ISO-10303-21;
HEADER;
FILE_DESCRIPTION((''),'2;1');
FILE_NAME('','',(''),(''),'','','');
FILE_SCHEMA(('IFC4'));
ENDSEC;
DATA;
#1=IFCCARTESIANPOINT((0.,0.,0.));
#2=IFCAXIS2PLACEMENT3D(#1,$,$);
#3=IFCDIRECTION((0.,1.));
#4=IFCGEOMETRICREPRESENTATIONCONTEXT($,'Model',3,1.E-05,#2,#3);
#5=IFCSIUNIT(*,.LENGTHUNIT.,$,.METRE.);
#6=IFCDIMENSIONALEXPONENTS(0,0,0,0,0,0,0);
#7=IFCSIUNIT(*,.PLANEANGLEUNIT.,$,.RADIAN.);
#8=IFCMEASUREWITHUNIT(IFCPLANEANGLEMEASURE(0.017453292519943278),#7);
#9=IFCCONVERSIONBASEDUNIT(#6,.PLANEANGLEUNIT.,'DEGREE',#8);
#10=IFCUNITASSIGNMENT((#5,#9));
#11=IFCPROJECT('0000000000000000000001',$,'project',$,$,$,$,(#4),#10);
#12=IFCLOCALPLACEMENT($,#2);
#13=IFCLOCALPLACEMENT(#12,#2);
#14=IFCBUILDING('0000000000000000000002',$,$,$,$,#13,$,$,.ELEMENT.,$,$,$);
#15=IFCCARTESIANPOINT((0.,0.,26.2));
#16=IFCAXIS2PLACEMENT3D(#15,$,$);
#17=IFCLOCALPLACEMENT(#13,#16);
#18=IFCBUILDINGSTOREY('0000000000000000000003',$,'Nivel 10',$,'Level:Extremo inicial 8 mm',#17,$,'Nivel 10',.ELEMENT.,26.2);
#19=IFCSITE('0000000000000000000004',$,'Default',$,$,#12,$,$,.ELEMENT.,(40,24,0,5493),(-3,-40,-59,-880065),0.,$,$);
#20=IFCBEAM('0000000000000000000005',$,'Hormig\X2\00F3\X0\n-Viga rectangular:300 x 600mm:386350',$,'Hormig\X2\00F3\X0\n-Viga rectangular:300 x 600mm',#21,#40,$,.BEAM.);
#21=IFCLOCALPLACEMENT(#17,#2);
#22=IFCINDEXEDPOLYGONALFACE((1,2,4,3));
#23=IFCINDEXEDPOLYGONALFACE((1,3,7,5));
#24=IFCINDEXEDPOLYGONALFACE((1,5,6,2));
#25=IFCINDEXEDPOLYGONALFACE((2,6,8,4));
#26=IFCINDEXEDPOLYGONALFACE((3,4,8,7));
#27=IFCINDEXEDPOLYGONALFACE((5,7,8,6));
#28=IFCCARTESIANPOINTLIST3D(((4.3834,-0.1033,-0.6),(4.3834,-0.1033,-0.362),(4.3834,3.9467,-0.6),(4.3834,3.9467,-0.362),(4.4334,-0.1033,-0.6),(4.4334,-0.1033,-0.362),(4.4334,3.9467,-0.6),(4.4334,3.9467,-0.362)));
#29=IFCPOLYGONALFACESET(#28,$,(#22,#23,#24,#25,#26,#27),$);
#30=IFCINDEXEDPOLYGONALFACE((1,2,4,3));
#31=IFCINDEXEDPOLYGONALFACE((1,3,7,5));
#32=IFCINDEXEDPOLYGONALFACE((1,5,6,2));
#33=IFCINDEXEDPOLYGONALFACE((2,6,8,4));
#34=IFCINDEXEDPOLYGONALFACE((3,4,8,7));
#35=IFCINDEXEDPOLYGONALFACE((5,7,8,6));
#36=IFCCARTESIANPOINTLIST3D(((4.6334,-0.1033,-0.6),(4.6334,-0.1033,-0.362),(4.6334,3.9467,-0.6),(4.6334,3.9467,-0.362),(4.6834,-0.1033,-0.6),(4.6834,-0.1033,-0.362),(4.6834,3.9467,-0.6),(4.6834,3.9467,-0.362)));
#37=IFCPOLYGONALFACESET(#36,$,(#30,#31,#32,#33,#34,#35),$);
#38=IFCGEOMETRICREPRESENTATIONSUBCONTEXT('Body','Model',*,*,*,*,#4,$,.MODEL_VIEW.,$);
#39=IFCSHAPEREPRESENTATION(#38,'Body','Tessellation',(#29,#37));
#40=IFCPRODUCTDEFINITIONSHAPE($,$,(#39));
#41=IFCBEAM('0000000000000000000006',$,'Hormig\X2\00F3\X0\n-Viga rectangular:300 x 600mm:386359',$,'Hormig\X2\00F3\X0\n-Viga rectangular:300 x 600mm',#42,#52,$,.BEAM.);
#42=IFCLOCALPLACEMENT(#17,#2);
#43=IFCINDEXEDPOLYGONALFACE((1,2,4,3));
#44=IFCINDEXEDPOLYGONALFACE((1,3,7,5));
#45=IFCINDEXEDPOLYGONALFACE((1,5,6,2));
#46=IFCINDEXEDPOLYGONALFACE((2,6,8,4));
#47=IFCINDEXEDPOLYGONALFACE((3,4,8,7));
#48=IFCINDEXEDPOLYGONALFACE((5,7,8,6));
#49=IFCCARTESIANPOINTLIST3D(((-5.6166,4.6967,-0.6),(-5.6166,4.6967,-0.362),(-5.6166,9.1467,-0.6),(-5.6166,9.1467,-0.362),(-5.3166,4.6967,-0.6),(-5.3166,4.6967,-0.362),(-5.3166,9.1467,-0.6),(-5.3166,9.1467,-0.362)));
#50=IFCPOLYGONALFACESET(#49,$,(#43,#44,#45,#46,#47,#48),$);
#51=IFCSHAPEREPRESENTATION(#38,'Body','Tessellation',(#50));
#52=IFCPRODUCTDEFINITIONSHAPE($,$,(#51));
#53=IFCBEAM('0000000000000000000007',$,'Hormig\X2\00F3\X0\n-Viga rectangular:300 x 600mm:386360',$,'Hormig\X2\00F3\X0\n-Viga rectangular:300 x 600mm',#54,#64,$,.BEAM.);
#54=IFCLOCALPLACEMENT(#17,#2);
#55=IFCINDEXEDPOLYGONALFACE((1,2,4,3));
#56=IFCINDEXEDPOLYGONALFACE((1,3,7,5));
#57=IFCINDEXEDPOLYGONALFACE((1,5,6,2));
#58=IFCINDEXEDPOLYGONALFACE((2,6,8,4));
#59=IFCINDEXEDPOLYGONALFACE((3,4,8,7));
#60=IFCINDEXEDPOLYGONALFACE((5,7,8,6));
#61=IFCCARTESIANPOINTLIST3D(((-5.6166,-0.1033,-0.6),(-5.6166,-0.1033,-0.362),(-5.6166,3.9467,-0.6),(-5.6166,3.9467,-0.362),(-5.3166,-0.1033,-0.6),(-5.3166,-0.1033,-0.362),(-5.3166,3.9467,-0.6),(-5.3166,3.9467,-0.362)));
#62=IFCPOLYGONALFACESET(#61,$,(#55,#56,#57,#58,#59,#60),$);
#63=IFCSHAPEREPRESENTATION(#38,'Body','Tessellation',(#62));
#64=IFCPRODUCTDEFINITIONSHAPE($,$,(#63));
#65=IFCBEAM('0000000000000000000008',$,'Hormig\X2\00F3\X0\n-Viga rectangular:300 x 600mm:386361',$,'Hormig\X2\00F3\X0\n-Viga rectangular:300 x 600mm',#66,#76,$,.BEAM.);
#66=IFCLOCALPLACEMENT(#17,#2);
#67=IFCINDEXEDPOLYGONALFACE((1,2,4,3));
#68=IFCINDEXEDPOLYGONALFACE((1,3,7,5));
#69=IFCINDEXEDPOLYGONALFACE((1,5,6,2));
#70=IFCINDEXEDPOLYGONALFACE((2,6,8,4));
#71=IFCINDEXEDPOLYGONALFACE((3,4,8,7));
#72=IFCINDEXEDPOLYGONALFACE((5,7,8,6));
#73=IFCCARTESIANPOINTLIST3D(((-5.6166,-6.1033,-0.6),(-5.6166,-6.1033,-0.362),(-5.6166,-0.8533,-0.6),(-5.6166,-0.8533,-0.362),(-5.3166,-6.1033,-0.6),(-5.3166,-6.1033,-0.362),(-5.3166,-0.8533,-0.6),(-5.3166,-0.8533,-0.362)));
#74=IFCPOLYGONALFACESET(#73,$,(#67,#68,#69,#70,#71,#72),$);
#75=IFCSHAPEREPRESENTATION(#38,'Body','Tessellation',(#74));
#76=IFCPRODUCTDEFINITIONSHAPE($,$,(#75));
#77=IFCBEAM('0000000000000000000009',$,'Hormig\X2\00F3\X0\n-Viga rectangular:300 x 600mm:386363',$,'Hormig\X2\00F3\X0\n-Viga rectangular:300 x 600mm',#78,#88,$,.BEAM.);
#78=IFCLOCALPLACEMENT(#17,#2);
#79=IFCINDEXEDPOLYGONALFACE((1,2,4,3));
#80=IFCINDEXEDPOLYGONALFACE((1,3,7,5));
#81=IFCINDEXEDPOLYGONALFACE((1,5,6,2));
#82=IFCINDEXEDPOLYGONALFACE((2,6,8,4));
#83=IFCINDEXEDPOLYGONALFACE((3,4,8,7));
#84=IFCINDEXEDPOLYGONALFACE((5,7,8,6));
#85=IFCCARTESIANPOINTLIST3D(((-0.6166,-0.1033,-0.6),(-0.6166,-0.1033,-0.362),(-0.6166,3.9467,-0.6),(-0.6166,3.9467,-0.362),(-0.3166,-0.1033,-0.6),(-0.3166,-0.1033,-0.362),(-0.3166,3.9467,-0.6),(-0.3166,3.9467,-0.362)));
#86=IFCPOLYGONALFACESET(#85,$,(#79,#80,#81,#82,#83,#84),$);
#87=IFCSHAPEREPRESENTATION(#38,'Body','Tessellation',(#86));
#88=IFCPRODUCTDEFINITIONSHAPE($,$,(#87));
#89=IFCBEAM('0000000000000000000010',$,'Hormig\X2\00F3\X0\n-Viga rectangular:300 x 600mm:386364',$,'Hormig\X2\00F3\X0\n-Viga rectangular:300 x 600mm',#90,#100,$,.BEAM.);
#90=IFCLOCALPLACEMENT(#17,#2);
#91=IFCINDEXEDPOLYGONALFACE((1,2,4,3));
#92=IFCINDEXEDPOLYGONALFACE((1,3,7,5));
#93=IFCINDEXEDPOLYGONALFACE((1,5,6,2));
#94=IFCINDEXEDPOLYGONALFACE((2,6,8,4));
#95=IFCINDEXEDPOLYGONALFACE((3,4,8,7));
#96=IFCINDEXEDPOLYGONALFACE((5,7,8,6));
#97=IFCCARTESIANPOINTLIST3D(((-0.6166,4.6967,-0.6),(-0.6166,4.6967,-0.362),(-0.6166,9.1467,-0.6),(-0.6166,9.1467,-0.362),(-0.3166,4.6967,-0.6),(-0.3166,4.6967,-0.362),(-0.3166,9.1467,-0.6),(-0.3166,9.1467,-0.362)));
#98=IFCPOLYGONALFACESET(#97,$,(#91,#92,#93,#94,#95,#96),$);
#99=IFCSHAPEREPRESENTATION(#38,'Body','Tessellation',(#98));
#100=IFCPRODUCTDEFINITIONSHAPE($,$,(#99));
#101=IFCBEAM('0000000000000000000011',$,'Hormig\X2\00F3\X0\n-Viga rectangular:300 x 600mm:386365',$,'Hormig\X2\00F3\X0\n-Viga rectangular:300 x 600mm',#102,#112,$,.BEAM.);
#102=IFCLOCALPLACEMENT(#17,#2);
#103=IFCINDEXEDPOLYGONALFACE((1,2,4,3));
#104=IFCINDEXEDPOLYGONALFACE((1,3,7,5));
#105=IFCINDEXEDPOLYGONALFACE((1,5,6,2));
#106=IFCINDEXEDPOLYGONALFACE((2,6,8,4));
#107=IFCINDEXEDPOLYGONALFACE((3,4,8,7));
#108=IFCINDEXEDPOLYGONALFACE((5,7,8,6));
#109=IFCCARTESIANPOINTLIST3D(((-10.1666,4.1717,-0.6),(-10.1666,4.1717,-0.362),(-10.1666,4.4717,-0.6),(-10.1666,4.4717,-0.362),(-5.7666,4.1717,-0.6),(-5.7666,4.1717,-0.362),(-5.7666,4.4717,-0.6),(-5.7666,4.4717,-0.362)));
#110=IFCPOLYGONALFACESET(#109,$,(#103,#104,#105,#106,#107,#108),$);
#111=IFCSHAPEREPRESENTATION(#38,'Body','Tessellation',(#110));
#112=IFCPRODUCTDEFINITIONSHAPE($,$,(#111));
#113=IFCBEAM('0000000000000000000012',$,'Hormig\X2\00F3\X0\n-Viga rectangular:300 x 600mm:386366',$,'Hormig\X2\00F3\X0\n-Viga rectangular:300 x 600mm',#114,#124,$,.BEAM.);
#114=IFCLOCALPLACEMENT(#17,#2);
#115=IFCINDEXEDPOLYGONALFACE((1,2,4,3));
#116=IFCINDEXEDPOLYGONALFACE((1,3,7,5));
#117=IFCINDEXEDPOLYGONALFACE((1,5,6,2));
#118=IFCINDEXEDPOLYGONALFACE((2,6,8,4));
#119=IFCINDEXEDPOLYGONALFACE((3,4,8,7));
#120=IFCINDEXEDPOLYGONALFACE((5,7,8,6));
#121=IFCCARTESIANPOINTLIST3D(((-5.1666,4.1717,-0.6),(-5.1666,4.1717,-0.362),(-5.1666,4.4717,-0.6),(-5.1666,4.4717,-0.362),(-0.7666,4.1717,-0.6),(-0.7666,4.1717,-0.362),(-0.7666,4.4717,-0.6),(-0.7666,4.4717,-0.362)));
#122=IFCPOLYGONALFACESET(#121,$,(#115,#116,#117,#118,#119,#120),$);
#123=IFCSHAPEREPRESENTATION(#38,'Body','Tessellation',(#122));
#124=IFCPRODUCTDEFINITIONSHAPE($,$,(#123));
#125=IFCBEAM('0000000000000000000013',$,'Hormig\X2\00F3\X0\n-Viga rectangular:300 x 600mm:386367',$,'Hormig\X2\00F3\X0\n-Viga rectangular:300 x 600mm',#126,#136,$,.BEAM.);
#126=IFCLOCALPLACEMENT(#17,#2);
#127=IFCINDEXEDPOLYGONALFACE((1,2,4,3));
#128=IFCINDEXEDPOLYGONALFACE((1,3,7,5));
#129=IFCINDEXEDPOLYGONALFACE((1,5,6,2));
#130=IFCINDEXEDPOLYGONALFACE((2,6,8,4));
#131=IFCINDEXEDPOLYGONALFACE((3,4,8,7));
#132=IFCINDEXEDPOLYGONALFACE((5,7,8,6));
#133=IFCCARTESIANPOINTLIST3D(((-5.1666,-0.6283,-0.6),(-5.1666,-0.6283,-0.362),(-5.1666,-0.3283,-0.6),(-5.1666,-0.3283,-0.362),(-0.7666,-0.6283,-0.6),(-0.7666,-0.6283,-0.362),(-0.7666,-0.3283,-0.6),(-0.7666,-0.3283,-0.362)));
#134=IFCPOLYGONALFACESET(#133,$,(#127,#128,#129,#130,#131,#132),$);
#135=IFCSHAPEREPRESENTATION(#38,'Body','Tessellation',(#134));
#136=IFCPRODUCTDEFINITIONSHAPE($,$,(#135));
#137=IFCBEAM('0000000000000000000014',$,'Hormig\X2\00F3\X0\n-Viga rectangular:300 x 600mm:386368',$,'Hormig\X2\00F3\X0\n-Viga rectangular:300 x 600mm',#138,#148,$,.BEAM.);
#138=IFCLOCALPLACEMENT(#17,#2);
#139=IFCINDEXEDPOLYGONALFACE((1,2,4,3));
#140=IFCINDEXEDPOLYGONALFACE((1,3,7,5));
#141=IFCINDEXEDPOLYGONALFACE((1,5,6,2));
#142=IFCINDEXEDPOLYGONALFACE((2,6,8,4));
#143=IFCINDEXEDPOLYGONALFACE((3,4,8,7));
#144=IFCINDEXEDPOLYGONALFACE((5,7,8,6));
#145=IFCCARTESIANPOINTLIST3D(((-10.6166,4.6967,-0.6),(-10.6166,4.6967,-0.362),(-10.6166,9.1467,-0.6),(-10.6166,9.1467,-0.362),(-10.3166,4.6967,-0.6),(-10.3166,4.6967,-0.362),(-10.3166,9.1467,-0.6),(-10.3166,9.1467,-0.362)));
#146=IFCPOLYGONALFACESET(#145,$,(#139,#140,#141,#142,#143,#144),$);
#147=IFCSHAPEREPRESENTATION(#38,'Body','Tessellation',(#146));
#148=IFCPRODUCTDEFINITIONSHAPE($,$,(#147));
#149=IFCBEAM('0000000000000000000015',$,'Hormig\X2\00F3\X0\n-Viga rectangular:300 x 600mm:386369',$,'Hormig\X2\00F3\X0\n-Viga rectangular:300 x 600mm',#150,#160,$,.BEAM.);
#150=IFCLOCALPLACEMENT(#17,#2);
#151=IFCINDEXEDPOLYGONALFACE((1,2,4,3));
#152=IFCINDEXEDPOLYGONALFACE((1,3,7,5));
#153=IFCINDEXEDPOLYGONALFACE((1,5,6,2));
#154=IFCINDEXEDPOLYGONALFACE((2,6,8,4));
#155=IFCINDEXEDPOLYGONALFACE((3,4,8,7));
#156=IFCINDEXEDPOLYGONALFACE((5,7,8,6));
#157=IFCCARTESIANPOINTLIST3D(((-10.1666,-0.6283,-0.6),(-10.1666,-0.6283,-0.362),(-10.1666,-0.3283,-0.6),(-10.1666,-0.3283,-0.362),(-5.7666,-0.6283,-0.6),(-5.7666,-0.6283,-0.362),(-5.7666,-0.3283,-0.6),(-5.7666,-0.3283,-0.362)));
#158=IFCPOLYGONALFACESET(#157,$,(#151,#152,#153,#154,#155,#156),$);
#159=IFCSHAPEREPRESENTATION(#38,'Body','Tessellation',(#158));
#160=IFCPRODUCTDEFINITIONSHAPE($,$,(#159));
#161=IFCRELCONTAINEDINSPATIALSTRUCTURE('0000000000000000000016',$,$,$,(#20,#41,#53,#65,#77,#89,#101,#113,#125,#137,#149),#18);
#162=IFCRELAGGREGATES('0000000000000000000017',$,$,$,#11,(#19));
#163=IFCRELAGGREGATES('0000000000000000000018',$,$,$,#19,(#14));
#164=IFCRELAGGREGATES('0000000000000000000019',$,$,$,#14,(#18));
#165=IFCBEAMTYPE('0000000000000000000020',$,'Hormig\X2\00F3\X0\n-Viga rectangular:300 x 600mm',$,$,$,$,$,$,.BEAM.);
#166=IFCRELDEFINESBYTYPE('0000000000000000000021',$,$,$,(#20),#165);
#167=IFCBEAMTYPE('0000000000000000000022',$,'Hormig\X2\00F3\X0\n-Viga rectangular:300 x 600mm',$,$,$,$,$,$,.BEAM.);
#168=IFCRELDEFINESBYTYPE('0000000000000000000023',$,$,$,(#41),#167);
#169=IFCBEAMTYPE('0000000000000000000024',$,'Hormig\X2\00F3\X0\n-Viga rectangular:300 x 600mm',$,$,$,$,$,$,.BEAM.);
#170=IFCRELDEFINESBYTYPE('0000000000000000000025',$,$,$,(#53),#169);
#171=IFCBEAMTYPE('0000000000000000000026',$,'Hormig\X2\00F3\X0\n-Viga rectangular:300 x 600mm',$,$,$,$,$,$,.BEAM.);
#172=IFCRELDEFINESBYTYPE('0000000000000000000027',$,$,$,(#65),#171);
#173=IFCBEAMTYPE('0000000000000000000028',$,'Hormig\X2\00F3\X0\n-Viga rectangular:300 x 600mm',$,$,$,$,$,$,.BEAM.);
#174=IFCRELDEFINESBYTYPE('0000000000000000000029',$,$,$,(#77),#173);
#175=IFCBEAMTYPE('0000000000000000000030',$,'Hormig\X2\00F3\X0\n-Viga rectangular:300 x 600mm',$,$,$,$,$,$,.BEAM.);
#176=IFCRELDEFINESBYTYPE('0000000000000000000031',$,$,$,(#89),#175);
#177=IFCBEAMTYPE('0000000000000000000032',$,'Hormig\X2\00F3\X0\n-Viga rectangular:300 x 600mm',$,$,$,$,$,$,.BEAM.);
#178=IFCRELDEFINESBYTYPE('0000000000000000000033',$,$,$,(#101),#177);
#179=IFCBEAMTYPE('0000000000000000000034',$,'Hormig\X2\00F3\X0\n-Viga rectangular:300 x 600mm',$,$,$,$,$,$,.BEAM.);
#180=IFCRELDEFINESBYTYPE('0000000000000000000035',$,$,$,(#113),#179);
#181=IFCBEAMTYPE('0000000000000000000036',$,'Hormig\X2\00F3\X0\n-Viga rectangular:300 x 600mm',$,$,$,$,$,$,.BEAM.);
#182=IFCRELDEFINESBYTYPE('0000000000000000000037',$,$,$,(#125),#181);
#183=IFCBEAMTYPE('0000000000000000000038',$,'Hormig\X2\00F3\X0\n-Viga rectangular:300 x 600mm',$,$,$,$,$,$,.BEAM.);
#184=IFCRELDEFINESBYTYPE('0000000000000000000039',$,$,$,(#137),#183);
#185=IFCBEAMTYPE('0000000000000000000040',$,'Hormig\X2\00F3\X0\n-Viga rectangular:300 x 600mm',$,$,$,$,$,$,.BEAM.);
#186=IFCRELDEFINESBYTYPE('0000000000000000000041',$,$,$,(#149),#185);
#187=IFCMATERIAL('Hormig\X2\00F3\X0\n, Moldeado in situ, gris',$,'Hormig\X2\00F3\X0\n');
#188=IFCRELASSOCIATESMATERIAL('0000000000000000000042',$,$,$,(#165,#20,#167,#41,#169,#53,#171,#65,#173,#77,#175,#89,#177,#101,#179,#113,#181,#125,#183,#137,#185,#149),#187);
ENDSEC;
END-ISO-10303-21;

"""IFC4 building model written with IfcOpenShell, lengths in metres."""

from ifc_helpers import new_model, entity, si_unit, converted_unit, direction, frame, origin, place, context, subcontext, project, spatial, indexed_curve, outline, extrude, source, transform, mapped, material, type_object, type_shapes, element, save


model = new_model("IFC4")

# Units and contexts
model_context = context("Model", 3, precision=1e-05, world=origin(), true_north=direction((0.0, 1.0)))
body_context = subcontext(model_context, "Body", "Model", "MODEL_VIEW")
ifc_project = project(units=[si_unit("LENGTHUNIT", "METRE"), converted_unit("PLANEANGLEUNIT", "DEGREE", entity("IfcPlaneAngleMeasure", 0.017453292519943278), si_unit("PLANEANGLEUNIT", "RADIAN"), dimensions=[0, 0, 0, 0, 0, 0, 0])], contexts=[model_context])

# Site, building, storey
site_placement = place(None, origin())
site = spatial("IfcSite", under=ifc_project, at=site_placement, Name="Default", CompositionType="ELEMENT", RefLatitude=(40, 24, 0, 5493), RefLongitude=(-3, -40, -59, -880065), RefElevation=0.0)
building_placement = place(site_placement, origin())
building = spatial("IfcBuilding", under=site, at=building_placement, CompositionType="ELEMENT")
storey_placement = place(building_placement, frame((0.0, 0.0, 26.2)))
storey = spatial("IfcBuildingStorey", under=building, at=storey_placement, Name="Nivel 10", ObjectType="Level:Extremo inicial 8 mm", LongName="Nivel 10", CompositionType="ELEMENT", Elevation=26.2)

# Shared definitions
ifc_material_1 = material(Name="Hormigón, Moldeado in situ, gris", Category="Hormigón")

# Beams
beam_type_1 = type_object("IfcBeamType", Name="Hormigón-Viga rectangular:300 x 600mm", PredefinedType="BEAM", material=ifc_material_1)
shared_shape_1 = source(origin(), body_context, "Body", "SweptSolid", [
    extrude(outline(indexed_curve([(-0.025, -0.119), (0.025, -0.119), (0.025, 0.119), (-0.025, 0.119), (-0.025, -0.119)], self_intersect=False)), frame((4.4084, 3.9467, 25.719), z_axis=(0.0, -1.0, 0.0), x_axis=(-1.0, 0.0, 0.0)), (0.0, 0.0, 1.0), 4.05),
    extrude(outline(indexed_curve([(-0.025, -0.119), (0.025, -0.119), (0.025, 0.119), (-0.025, 0.119), (-0.025, -0.119)], self_intersect=False)), frame((4.6584, 3.9467, 25.719), z_axis=(0.0, -1.0, 0.0), x_axis=(-1.0, 0.0, 0.0)), (0.0, 0.0, 1.0), 4.05),
])
type_shapes(beam_type_1, [shared_shape_1])
beam_1_placement = place(storey_placement, frame((0.0, 0.0, -26.2)))
element("IfcBeam", 1, at=beam_1_placement, inside=storey, type_object=beam_type_1, material=ifc_material_1, Name="Hormigón-Viga rectangular:300 x 600mm:386350", ObjectType="Hormigón-Viga rectangular:300 x 600mm", PredefinedType="BEAM", context=body_context, shape_type="MappedRepresentation", body=[
    mapped(shared_shape_1, transform((0.0, 0.0, 0.0), scale=1.0)),
])
beam_type_2 = type_object("IfcBeamType", Name="Hormigón-Viga rectangular:300 x 600mm", PredefinedType="BEAM", material=ifc_material_1)
shared_shape_2 = source(origin(), body_context, "Body", "SweptSolid", [
    extrude(outline(indexed_curve([(-0.15, -0.119), (0.15, -0.119), (0.15, 0.119), (-0.15, 0.119), (-0.15, -0.119)], self_intersect=False)), frame((-5.4666, 9.1467, 25.719), z_axis=(0.0, -1.0, 0.0), x_axis=(-1.0, 0.0, 0.0)), (0.0, 0.0, 1.0), 4.45),
])
type_shapes(beam_type_2, [shared_shape_2])
beam_2_placement = place(storey_placement, frame((0.0, 0.0, -26.2)))
element("IfcBeam", 2, at=beam_2_placement, inside=storey, type_object=beam_type_2, material=ifc_material_1, Name="Hormigón-Viga rectangular:300 x 600mm:386359", ObjectType="Hormigón-Viga rectangular:300 x 600mm", PredefinedType="BEAM", context=body_context, shape_type="MappedRepresentation", body=[
    mapped(shared_shape_2, transform((0.0, 0.0, 0.0), scale=1.0)),
])
beam_type_3 = type_object("IfcBeamType", Name="Hormigón-Viga rectangular:300 x 600mm", PredefinedType="BEAM", material=ifc_material_1)
shared_shape_3 = source(origin(), body_context, "Body", "SweptSolid", [
    extrude(outline(indexed_curve([(-0.15, -0.119), (0.15, -0.119), (0.15, 0.119), (-0.15, 0.119), (-0.15, -0.119)], self_intersect=False)), frame((-5.4666, 3.9467, 25.719), z_axis=(0.0, -1.0, 0.0), x_axis=(-1.0, 0.0, 0.0)), (0.0, 0.0, 1.0), 4.05),
])
type_shapes(beam_type_3, [shared_shape_3])
beam_3_placement = place(storey_placement, frame((0.0, 0.0, -26.2)))
element("IfcBeam", 3, at=beam_3_placement, inside=storey, type_object=beam_type_3, material=ifc_material_1, Name="Hormigón-Viga rectangular:300 x 600mm:386360", ObjectType="Hormigón-Viga rectangular:300 x 600mm", PredefinedType="BEAM", context=body_context, shape_type="MappedRepresentation", body=[
    mapped(shared_shape_3, transform((0.0, 0.0, 0.0), scale=1.0)),
])
beam_type_4 = type_object("IfcBeamType", Name="Hormigón-Viga rectangular:300 x 600mm", PredefinedType="BEAM", material=ifc_material_1)
shared_shape_4 = source(origin(), body_context, "Body", "SweptSolid", [
    extrude(outline(indexed_curve([(-0.15, -0.119), (0.15, -0.119), (0.15, 0.119), (-0.15, 0.119), (-0.15, -0.119)], self_intersect=False)), frame((-5.4666, -6.1033, 25.719), z_axis=(0.0, 1.0, 0.0), x_axis=(-1.0, 0.0, 0.0)), (0.0, 0.0, 1.0), 5.25),
])
type_shapes(beam_type_4, [shared_shape_4])
beam_4_placement = place(storey_placement, frame((0.0, 0.0, -26.2)))
element("IfcBeam", 4, at=beam_4_placement, inside=storey, type_object=beam_type_4, material=ifc_material_1, Name="Hormigón-Viga rectangular:300 x 600mm:386361", ObjectType="Hormigón-Viga rectangular:300 x 600mm", PredefinedType="BEAM", context=body_context, shape_type="MappedRepresentation", body=[
    mapped(shared_shape_4, transform((0.0, 0.0, 0.0), scale=1.0)),
])
beam_type_5 = type_object("IfcBeamType", Name="Hormigón-Viga rectangular:300 x 600mm", PredefinedType="BEAM", material=ifc_material_1)
shared_shape_5 = source(origin(), body_context, "Body", "SweptSolid", [
    extrude(outline(indexed_curve([(-0.15, -0.119), (0.15, -0.119), (0.15, 0.119), (-0.15, 0.119), (-0.15, -0.119)], self_intersect=False)), frame((-0.4666, -0.1033, 25.719), z_axis=(0.0, 1.0, 0.0), x_axis=(-1.0, 0.0, 0.0)), (0.0, 0.0, 1.0), 4.05),
])
type_shapes(beam_type_5, [shared_shape_5])
beam_5_placement = place(storey_placement, frame((0.0, 0.0, -26.2)))
element("IfcBeam", 5, at=beam_5_placement, inside=storey, type_object=beam_type_5, material=ifc_material_1, Name="Hormigón-Viga rectangular:300 x 600mm:386363", ObjectType="Hormigón-Viga rectangular:300 x 600mm", PredefinedType="BEAM", context=body_context, shape_type="MappedRepresentation", body=[
    mapped(shared_shape_5, transform((0.0, 0.0, 0.0), scale=1.0)),
])
beam_type_6 = type_object("IfcBeamType", Name="Hormigón-Viga rectangular:300 x 600mm", PredefinedType="BEAM", material=ifc_material_1)
shared_shape_6 = source(origin(), body_context, "Body", "SweptSolid", [
    extrude(outline(indexed_curve([(-0.15, -0.119), (0.15, -0.119), (0.15, 0.119), (-0.15, 0.119), (-0.15, -0.119)], self_intersect=False)), frame((-0.4666, 9.1467, 25.719), z_axis=(0.0, -1.0, 0.0), x_axis=(-1.0, 0.0, 0.0)), (0.0, 0.0, 1.0), 4.45),
])
type_shapes(beam_type_6, [shared_shape_6])
beam_6_placement = place(storey_placement, frame((0.0, 0.0, -26.2)))
element("IfcBeam", 6, at=beam_6_placement, inside=storey, type_object=beam_type_6, material=ifc_material_1, Name="Hormigón-Viga rectangular:300 x 600mm:386364", ObjectType="Hormigón-Viga rectangular:300 x 600mm", PredefinedType="BEAM", context=body_context, shape_type="MappedRepresentation", body=[
    mapped(shared_shape_6, transform((0.0, 0.0, 0.0), scale=1.0)),
])
beam_type_7 = type_object("IfcBeamType", Name="Hormigón-Viga rectangular:300 x 600mm", PredefinedType="BEAM", material=ifc_material_1)
shared_shape_7 = source(origin(), body_context, "Body", "SweptSolid", [
    extrude(outline(indexed_curve([(-0.119, -0.15), (0.119, -0.15), (0.119, 0.15), (-0.119, 0.15), (-0.119, -0.15)], self_intersect=False)), frame((-10.1666, 4.3217, 25.719), z_axis=(1.0, 0.0, 0.0), x_axis=(0.0, 0.0, -1.0)), (0.0, 0.0, 1.0), 4.4),
])
type_shapes(beam_type_7, [shared_shape_7])
beam_7_placement = place(storey_placement, frame((0.0, 0.0, -26.2)))
element("IfcBeam", 7, at=beam_7_placement, inside=storey, type_object=beam_type_7, material=ifc_material_1, Name="Hormigón-Viga rectangular:300 x 600mm:386365", ObjectType="Hormigón-Viga rectangular:300 x 600mm", PredefinedType="BEAM", context=body_context, shape_type="MappedRepresentation", body=[
    mapped(shared_shape_7, transform((0.0, 0.0, 0.0), scale=1.0)),
])
beam_type_8 = type_object("IfcBeamType", Name="Hormigón-Viga rectangular:300 x 600mm", PredefinedType="BEAM", material=ifc_material_1)
shared_shape_8 = source(origin(), body_context, "Body", "SweptSolid", [
    extrude(outline(indexed_curve([(-0.119, -0.15), (0.119, -0.15), (0.119, 0.15), (-0.119, 0.15), (-0.119, -0.15)], self_intersect=False)), frame((-5.1666, 4.3217, 25.719), z_axis=(1.0, 0.0, 0.0), x_axis=(0.0, 0.0, -1.0)), (0.0, 0.0, 1.0), 4.4),
])
type_shapes(beam_type_8, [shared_shape_8])
beam_8_placement = place(storey_placement, frame((0.0, 0.0, -26.2)))
element("IfcBeam", 8, at=beam_8_placement, inside=storey, type_object=beam_type_8, material=ifc_material_1, Name="Hormigón-Viga rectangular:300 x 600mm:386366", ObjectType="Hormigón-Viga rectangular:300 x 600mm", PredefinedType="BEAM", context=body_context, shape_type="MappedRepresentation", body=[
    mapped(shared_shape_8, transform((0.0, 0.0, 0.0), scale=1.0)),
])
beam_type_9 = type_object("IfcBeamType", Name="Hormigón-Viga rectangular:300 x 600mm", PredefinedType="BEAM", material=ifc_material_1)
shared_shape_9 = source(origin(), body_context, "Body", "SweptSolid", [
    extrude(outline(indexed_curve([(-0.119, -0.15), (0.119, -0.15), (0.119, 0.15), (-0.119, 0.15), (-0.119, -0.15)], self_intersect=False)), frame((-0.7666, -0.4783, 25.719), z_axis=(-1.0, 0.0, 0.0), x_axis=(0.0, 0.0, -1.0)), (0.0, 0.0, 1.0), 4.4),
])
type_shapes(beam_type_9, [shared_shape_9])
beam_9_placement = place(storey_placement, frame((0.0, 0.0, -26.2)))
element("IfcBeam", 9, at=beam_9_placement, inside=storey, type_object=beam_type_9, material=ifc_material_1, Name="Hormigón-Viga rectangular:300 x 600mm:386367", ObjectType="Hormigón-Viga rectangular:300 x 600mm", PredefinedType="BEAM", context=body_context, shape_type="MappedRepresentation", body=[
    mapped(shared_shape_9, transform((0.0, 0.0, 0.0), scale=1.0)),
])
beam_type_10 = type_object("IfcBeamType", Name="Hormigón-Viga rectangular:300 x 600mm", PredefinedType="BEAM", material=ifc_material_1)
shared_shape_10 = source(origin(), body_context, "Body", "SweptSolid", [
    extrude(outline(indexed_curve([(-0.15, -0.119), (0.15, -0.119), (0.15, 0.119), (-0.15, 0.119), (-0.15, -0.119)], self_intersect=False)), frame((-10.4666, 4.6967, 25.719), z_axis=(0.0, 1.0, 0.0), x_axis=(-1.0, 0.0, 0.0)), (0.0, 0.0, 1.0), 4.45),
])
type_shapes(beam_type_10, [shared_shape_10])
beam_10_placement = place(storey_placement, frame((0.0, 0.0, -26.2)))
element("IfcBeam", 10, at=beam_10_placement, inside=storey, type_object=beam_type_10, material=ifc_material_1, Name="Hormigón-Viga rectangular:300 x 600mm:386368", ObjectType="Hormigón-Viga rectangular:300 x 600mm", PredefinedType="BEAM", context=body_context, shape_type="MappedRepresentation", body=[
    mapped(shared_shape_10, transform((0.0, 0.0, 0.0), scale=1.0)),
])
beam_type_11 = type_object("IfcBeamType", Name="Hormigón-Viga rectangular:300 x 600mm", PredefinedType="BEAM", material=ifc_material_1)
shared_shape_11 = source(origin(), body_context, "Body", "SweptSolid", [
    extrude(outline(indexed_curve([(-0.119, -0.15), (0.119, -0.15), (0.119, 0.15), (-0.119, 0.15), (-0.119, -0.15)], self_intersect=False)), frame((-10.1666, -0.4783, 25.719), z_axis=(1.0, 0.0, 0.0), x_axis=(0.0, 0.0, -1.0)), (0.0, 0.0, 1.0), 4.4),
])
type_shapes(beam_type_11, [shared_shape_11])
beam_11_placement = place(storey_placement, frame((0.0, 0.0, -26.2)))
element("IfcBeam", 11, at=beam_11_placement, inside=storey, type_object=beam_type_11, material=ifc_material_1, Name="Hormigón-Viga rectangular:300 x 600mm:386369", ObjectType="Hormigón-Viga rectangular:300 x 600mm", PredefinedType="BEAM", context=body_context, shape_type="MappedRepresentation", body=[
    mapped(shared_shape_11, transform((0.0, 0.0, 0.0), scale=1.0)),
])

save(model, "model.ifc")
